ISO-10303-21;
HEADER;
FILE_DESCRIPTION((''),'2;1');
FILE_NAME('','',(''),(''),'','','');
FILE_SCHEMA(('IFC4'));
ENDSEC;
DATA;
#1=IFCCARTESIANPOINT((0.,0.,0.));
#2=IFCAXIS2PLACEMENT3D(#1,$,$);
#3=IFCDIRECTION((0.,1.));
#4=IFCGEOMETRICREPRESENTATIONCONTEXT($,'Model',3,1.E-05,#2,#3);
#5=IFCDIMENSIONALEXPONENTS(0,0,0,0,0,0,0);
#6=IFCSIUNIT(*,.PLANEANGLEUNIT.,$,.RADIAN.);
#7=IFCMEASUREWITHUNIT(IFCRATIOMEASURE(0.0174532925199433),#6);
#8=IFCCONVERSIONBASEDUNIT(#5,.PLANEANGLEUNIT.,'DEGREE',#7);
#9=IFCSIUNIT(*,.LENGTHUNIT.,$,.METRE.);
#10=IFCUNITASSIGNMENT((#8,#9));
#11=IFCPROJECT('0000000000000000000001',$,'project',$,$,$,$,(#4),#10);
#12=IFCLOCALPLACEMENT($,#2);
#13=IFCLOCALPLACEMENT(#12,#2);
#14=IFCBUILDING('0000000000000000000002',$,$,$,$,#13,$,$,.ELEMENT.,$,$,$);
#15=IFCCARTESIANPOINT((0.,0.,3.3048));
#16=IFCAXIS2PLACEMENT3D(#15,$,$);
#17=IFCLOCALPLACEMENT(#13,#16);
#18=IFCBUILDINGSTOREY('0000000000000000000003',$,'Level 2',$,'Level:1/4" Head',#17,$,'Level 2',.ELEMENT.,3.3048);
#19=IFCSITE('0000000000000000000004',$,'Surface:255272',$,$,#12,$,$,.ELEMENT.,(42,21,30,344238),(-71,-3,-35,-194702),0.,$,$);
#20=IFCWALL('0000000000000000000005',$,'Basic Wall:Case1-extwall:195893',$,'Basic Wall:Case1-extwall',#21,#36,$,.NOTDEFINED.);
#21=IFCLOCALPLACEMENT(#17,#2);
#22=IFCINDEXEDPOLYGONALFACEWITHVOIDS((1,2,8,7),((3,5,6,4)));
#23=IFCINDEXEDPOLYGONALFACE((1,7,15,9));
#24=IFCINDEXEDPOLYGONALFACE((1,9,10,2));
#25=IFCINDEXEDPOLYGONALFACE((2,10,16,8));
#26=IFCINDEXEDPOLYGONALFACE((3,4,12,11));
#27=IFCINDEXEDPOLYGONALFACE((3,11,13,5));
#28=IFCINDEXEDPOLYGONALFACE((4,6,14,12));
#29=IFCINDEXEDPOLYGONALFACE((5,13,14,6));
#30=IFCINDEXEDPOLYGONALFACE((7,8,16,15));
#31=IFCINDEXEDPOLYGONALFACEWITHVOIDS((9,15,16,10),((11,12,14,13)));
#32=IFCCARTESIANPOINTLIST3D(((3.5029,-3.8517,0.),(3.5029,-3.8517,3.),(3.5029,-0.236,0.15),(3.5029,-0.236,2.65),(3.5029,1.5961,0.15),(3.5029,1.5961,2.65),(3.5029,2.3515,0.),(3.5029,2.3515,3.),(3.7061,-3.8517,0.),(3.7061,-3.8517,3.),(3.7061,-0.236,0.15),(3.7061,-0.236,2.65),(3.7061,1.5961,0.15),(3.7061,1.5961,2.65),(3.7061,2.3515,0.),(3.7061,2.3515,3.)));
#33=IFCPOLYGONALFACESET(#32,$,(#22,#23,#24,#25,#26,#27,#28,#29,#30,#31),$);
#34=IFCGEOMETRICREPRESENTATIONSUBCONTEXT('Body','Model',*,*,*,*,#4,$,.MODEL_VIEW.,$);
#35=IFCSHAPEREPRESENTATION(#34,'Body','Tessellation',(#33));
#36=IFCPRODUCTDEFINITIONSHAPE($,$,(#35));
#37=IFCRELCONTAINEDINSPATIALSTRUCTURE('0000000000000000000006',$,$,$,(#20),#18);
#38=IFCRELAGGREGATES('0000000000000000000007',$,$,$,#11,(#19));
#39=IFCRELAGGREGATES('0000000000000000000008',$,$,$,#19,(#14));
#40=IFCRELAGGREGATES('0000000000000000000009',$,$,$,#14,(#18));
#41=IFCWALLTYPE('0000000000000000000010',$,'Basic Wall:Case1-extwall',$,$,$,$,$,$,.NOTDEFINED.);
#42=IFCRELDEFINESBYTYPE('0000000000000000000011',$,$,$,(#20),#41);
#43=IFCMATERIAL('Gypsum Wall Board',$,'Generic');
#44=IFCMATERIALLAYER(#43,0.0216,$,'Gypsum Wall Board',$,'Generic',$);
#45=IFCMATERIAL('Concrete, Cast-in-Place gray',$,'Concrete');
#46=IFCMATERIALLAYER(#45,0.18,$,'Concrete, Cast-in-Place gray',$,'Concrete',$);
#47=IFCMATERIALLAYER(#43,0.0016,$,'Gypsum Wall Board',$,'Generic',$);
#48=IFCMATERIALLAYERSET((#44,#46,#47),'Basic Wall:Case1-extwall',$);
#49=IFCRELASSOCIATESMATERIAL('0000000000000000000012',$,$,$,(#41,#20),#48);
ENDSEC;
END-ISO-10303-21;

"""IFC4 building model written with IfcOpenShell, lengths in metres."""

from ifc_helpers import new_model, entity, si_unit, converted_unit, direction, frame, frame_2d, origin, place, context, subcontext, project, spatial, polyline, rectangle, extrude, clip, bounded_halfspace, material, layer, layer_set, layer_usage, type_object, element, save


model = new_model("IFC4")

# Units and contexts
model_context = context("Model", 3, precision=1e-05, world=origin(), true_north=direction((0.0, 1.0)))
body_context = subcontext(model_context, "Body", "Model", "MODEL_VIEW")
ifc_project = project(units=[converted_unit("PLANEANGLEUNIT", "DEGREE", entity("IfcRatioMeasure", 0.0174532925199433), si_unit("PLANEANGLEUNIT", "RADIAN"), dimensions=[0, 0, 0, 0, 0, 0, 0]), si_unit("LENGTHUNIT", "METRE")], contexts=[model_context])

# Site, building, storey
site_placement = place(None, origin())
site = spatial("IfcSite", under=ifc_project, at=site_placement, Name="Surface:255272", CompositionType="ELEMENT", RefLatitude=(42, 21, 30, 344238), RefLongitude=(-71, -3, -35, -194702), RefElevation=0.0)
building_placement = place(site_placement, origin())
building = spatial("IfcBuilding", under=site, at=building_placement, CompositionType="ELEMENT")
storey_placement = place(building_placement, frame((0.0, 0.0, 3.3048)))
storey = spatial("IfcBuildingStorey", under=building, at=storey_placement, Name="Level 2", ObjectType="Level:1/4\" Head", LongName="Level 2", CompositionType="ELEMENT", Elevation=3.3048)

# Wall, opening
ifc_material_1 = material(Name="Gypsum Wall Board", Category="Generic")
ifc_layer_1 = layer(ifc_material_1, 0.0216, Name="Gypsum Wall Board", Category="Generic")
ifc_material_2 = material(Name="Concrete, Cast-in-Place gray", Category="Concrete")
ifc_layer_2 = layer(ifc_material_2, 0.18, Name="Concrete, Cast-in-Place gray", Category="Concrete")
ifc_layer_3 = layer(ifc_material_1, 0.0016, Name="Gypsum Wall Board", Category="Generic")
ifc_layer_set = layer_set([ifc_layer_1, ifc_layer_2, ifc_layer_3], Name="Basic Wall:Case1-extwall")
ifc_layer_usage_1 = layer_usage(ifc_layer_set, "AXIS2", "NEGATIVE", 0.1016)
wall_type = type_object("IfcWallType", Name="Basic Wall:Case1-extwall", PredefinedType="NOTDEFINED", material=ifc_layer_set)
wall_1_placement = place(storey_placement, frame((3.6045, -3.8517, 0.0), z_axis=(0.0, 0.0, 1.0), x_axis=(0.000007, 1.0, 0.0)))
wall_1 = element("IfcWall", 1, at=wall_1_placement, inside=storey, type_object=wall_type, material=ifc_layer_usage_1, Name="Basic Wall:Case1-extwall:195893", ObjectType="Basic Wall:Case1-extwall", PredefinedType="NOTDEFINED", context=body_context, shape_type="Clipping", body=[
    clip(extrude(rectangle(XDim=6.2032, YDim=0.2032, at=frame_2d((3.1016, 0.0), x_axis=(-1.0, 0.0))), origin(), (0.0, 0.0, 1.0), 3.0), bounded_halfspace(frame((0.0, -0.1016, 3.0), z_axis=(0.0, 0.0, 1.0), x_axis=(0.0, -1.0, 0.0)), False, frame((0.0, -0.1016, 3.0)), polyline([(0.0, 0.0), (6.2032, 0.0), (6.2032, 0.2032), (0.2032, 0.2032), (0.0, 0.2032), (0.0, 0.0)]))),
])
opening_1_placement = place(wall_1_placement, frame((3.6157, 0.1016, 0.15)))
element("IfcOpeningElement", 2, at=opening_1_placement, cuts=wall_1, ObjectType="Opening", PredefinedType="OPENING", context=body_context, shape_type="SweptSolid", body=[
    extrude(rectangle(XDim=2.5, YDim=1.8321, at=frame_2d((0.0, 0.0), x_axis=(1.0, 0.0))), frame((0.916, -0.2032, 1.25), z_axis=(0.0, 1.0, 0.0), x_axis=(0.0, 0.0, -1.0)), (0.0, 0.0, 1.0), 0.2032),
])

save(model, "model.ifc")
